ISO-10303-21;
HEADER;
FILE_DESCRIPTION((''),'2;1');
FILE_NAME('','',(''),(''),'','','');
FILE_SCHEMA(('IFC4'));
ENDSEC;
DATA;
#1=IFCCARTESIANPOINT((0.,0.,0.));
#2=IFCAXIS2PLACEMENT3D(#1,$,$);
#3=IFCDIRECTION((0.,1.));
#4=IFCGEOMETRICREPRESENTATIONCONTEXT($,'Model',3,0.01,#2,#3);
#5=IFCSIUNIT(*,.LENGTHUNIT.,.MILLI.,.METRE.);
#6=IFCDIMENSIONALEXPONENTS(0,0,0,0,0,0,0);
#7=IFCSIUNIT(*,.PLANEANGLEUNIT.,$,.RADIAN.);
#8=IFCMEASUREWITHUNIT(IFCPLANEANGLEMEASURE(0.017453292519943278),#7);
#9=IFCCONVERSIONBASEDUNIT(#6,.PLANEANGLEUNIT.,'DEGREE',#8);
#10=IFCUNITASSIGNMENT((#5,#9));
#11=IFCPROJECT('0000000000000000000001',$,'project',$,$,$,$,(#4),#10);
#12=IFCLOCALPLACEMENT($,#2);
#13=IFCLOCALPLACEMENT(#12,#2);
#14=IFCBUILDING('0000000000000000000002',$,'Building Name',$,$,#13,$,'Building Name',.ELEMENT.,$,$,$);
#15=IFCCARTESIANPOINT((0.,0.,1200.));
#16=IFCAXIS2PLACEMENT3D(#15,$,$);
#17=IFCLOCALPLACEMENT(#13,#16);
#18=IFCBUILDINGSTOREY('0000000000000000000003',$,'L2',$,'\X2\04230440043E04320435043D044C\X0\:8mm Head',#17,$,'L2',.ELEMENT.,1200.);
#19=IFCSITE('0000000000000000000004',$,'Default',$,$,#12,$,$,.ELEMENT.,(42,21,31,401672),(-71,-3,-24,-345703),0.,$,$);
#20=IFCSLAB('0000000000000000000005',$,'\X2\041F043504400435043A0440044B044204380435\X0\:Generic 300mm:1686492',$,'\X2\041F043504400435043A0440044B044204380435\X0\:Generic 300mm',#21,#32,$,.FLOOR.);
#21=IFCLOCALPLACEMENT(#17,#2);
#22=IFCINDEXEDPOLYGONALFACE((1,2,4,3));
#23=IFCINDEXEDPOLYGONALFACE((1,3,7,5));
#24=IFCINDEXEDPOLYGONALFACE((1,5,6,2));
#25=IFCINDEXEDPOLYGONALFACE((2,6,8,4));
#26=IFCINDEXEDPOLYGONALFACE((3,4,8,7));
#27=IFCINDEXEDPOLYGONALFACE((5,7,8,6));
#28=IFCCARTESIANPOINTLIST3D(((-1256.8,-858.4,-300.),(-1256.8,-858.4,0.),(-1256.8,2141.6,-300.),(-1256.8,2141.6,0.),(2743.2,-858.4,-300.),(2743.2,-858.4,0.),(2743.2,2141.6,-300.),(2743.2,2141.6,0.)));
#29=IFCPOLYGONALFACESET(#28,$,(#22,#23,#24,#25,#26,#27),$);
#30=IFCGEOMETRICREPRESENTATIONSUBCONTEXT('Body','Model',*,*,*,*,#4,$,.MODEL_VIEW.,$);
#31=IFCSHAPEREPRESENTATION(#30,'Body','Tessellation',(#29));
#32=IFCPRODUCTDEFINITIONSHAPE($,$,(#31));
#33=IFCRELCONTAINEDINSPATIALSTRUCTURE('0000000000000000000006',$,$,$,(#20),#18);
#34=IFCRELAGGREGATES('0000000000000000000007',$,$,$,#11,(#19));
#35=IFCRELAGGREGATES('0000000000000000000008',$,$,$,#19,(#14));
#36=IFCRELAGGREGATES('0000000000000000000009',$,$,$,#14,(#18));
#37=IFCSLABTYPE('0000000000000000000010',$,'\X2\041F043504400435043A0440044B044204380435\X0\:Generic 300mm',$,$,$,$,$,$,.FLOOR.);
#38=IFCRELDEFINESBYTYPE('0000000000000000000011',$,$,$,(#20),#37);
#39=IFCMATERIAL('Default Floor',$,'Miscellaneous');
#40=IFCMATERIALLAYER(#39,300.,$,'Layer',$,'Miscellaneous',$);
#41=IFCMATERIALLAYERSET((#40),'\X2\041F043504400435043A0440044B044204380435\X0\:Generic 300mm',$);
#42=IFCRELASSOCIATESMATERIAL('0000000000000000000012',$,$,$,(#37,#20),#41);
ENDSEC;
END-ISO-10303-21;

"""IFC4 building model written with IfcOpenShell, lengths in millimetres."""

from ifc_helpers import new_model, entity, si_unit, converted_unit, direction, frame, origin, origin_2d_with_axis, place, context, subcontext, project, spatial, rectangle, extrude, material, layer, layer_set, layer_usage, type_object, element, save


model = new_model("IFC4")

# Units and contexts
model_context = context("Model", 3, precision=0.01, world=origin(), true_north=direction((0.0, 1.0)))
body_context = subcontext(model_context, "Body", "Model", "MODEL_VIEW")
ifc_project = project(units=[si_unit("LENGTHUNIT", "METRE", prefix="MILLI"), converted_unit("PLANEANGLEUNIT", "DEGREE", entity("IfcPlaneAngleMeasure", 0.017453292519943278), si_unit("PLANEANGLEUNIT", "RADIAN"), dimensions=[0, 0, 0, 0, 0, 0, 0])], contexts=[model_context])

# Site, building, storey
site_placement = place(None, origin())
site = spatial("IfcSite", under=ifc_project, at=site_placement, Name="Default", CompositionType="ELEMENT", RefLatitude=(42, 21, 31, 401672), RefLongitude=(-71, -3, -24, -345703), RefElevation=0.0)
building_placement = place(site_placement, origin())
building = spatial("IfcBuilding", under=site, at=building_placement, Name="Building Name", LongName="Building Name", CompositionType="ELEMENT")
storey_placement = place(building_placement, frame((0.0, 0.0, 1200.0)))
storey = spatial("IfcBuildingStorey", under=building, at=storey_placement, Name="L2", ObjectType="Уровень:8mm Head", LongName="L2", CompositionType="ELEMENT", Elevation=1200.0)

# Slab
ifc_material = material(Name="Default Floor", Category="Miscellaneous")
ifc_layer = layer(ifc_material, 300.0, Name="Layer", Category="Miscellaneous")
ifc_layer_set = layer_set([ifc_layer], Name="Перекрытие:Generic 300mm")
ifc_layer_usage = layer_usage(ifc_layer_set, "AXIS3", "POSITIVE", 0.0)
slab_type = type_object("IfcSlabType", Name="Перекрытие:Generic 300mm", PredefinedType="FLOOR", material=ifc_layer_set)
slab_placement = place(storey_placement, origin())
element("IfcSlab", 1, at=slab_placement, inside=storey, type_object=slab_type, material=ifc_layer_usage, Name="Перекрытие:Generic 300mm:1686492", ObjectType="Перекрытие:Generic 300mm", PredefinedType="FLOOR", context=body_context, shape_type="SweptSolid", body=[
    extrude(rectangle(XDim=3000.0, YDim=4000.0, at=origin_2d_with_axis()), frame((743.2, 641.6, 0.0), z_axis=(0.0, 0.0, -1.0), x_axis=(0.0, 1.0, 0.0)), (0.0, 0.0, 1.0), 300.0),
])

save(model, "model.ifc")
